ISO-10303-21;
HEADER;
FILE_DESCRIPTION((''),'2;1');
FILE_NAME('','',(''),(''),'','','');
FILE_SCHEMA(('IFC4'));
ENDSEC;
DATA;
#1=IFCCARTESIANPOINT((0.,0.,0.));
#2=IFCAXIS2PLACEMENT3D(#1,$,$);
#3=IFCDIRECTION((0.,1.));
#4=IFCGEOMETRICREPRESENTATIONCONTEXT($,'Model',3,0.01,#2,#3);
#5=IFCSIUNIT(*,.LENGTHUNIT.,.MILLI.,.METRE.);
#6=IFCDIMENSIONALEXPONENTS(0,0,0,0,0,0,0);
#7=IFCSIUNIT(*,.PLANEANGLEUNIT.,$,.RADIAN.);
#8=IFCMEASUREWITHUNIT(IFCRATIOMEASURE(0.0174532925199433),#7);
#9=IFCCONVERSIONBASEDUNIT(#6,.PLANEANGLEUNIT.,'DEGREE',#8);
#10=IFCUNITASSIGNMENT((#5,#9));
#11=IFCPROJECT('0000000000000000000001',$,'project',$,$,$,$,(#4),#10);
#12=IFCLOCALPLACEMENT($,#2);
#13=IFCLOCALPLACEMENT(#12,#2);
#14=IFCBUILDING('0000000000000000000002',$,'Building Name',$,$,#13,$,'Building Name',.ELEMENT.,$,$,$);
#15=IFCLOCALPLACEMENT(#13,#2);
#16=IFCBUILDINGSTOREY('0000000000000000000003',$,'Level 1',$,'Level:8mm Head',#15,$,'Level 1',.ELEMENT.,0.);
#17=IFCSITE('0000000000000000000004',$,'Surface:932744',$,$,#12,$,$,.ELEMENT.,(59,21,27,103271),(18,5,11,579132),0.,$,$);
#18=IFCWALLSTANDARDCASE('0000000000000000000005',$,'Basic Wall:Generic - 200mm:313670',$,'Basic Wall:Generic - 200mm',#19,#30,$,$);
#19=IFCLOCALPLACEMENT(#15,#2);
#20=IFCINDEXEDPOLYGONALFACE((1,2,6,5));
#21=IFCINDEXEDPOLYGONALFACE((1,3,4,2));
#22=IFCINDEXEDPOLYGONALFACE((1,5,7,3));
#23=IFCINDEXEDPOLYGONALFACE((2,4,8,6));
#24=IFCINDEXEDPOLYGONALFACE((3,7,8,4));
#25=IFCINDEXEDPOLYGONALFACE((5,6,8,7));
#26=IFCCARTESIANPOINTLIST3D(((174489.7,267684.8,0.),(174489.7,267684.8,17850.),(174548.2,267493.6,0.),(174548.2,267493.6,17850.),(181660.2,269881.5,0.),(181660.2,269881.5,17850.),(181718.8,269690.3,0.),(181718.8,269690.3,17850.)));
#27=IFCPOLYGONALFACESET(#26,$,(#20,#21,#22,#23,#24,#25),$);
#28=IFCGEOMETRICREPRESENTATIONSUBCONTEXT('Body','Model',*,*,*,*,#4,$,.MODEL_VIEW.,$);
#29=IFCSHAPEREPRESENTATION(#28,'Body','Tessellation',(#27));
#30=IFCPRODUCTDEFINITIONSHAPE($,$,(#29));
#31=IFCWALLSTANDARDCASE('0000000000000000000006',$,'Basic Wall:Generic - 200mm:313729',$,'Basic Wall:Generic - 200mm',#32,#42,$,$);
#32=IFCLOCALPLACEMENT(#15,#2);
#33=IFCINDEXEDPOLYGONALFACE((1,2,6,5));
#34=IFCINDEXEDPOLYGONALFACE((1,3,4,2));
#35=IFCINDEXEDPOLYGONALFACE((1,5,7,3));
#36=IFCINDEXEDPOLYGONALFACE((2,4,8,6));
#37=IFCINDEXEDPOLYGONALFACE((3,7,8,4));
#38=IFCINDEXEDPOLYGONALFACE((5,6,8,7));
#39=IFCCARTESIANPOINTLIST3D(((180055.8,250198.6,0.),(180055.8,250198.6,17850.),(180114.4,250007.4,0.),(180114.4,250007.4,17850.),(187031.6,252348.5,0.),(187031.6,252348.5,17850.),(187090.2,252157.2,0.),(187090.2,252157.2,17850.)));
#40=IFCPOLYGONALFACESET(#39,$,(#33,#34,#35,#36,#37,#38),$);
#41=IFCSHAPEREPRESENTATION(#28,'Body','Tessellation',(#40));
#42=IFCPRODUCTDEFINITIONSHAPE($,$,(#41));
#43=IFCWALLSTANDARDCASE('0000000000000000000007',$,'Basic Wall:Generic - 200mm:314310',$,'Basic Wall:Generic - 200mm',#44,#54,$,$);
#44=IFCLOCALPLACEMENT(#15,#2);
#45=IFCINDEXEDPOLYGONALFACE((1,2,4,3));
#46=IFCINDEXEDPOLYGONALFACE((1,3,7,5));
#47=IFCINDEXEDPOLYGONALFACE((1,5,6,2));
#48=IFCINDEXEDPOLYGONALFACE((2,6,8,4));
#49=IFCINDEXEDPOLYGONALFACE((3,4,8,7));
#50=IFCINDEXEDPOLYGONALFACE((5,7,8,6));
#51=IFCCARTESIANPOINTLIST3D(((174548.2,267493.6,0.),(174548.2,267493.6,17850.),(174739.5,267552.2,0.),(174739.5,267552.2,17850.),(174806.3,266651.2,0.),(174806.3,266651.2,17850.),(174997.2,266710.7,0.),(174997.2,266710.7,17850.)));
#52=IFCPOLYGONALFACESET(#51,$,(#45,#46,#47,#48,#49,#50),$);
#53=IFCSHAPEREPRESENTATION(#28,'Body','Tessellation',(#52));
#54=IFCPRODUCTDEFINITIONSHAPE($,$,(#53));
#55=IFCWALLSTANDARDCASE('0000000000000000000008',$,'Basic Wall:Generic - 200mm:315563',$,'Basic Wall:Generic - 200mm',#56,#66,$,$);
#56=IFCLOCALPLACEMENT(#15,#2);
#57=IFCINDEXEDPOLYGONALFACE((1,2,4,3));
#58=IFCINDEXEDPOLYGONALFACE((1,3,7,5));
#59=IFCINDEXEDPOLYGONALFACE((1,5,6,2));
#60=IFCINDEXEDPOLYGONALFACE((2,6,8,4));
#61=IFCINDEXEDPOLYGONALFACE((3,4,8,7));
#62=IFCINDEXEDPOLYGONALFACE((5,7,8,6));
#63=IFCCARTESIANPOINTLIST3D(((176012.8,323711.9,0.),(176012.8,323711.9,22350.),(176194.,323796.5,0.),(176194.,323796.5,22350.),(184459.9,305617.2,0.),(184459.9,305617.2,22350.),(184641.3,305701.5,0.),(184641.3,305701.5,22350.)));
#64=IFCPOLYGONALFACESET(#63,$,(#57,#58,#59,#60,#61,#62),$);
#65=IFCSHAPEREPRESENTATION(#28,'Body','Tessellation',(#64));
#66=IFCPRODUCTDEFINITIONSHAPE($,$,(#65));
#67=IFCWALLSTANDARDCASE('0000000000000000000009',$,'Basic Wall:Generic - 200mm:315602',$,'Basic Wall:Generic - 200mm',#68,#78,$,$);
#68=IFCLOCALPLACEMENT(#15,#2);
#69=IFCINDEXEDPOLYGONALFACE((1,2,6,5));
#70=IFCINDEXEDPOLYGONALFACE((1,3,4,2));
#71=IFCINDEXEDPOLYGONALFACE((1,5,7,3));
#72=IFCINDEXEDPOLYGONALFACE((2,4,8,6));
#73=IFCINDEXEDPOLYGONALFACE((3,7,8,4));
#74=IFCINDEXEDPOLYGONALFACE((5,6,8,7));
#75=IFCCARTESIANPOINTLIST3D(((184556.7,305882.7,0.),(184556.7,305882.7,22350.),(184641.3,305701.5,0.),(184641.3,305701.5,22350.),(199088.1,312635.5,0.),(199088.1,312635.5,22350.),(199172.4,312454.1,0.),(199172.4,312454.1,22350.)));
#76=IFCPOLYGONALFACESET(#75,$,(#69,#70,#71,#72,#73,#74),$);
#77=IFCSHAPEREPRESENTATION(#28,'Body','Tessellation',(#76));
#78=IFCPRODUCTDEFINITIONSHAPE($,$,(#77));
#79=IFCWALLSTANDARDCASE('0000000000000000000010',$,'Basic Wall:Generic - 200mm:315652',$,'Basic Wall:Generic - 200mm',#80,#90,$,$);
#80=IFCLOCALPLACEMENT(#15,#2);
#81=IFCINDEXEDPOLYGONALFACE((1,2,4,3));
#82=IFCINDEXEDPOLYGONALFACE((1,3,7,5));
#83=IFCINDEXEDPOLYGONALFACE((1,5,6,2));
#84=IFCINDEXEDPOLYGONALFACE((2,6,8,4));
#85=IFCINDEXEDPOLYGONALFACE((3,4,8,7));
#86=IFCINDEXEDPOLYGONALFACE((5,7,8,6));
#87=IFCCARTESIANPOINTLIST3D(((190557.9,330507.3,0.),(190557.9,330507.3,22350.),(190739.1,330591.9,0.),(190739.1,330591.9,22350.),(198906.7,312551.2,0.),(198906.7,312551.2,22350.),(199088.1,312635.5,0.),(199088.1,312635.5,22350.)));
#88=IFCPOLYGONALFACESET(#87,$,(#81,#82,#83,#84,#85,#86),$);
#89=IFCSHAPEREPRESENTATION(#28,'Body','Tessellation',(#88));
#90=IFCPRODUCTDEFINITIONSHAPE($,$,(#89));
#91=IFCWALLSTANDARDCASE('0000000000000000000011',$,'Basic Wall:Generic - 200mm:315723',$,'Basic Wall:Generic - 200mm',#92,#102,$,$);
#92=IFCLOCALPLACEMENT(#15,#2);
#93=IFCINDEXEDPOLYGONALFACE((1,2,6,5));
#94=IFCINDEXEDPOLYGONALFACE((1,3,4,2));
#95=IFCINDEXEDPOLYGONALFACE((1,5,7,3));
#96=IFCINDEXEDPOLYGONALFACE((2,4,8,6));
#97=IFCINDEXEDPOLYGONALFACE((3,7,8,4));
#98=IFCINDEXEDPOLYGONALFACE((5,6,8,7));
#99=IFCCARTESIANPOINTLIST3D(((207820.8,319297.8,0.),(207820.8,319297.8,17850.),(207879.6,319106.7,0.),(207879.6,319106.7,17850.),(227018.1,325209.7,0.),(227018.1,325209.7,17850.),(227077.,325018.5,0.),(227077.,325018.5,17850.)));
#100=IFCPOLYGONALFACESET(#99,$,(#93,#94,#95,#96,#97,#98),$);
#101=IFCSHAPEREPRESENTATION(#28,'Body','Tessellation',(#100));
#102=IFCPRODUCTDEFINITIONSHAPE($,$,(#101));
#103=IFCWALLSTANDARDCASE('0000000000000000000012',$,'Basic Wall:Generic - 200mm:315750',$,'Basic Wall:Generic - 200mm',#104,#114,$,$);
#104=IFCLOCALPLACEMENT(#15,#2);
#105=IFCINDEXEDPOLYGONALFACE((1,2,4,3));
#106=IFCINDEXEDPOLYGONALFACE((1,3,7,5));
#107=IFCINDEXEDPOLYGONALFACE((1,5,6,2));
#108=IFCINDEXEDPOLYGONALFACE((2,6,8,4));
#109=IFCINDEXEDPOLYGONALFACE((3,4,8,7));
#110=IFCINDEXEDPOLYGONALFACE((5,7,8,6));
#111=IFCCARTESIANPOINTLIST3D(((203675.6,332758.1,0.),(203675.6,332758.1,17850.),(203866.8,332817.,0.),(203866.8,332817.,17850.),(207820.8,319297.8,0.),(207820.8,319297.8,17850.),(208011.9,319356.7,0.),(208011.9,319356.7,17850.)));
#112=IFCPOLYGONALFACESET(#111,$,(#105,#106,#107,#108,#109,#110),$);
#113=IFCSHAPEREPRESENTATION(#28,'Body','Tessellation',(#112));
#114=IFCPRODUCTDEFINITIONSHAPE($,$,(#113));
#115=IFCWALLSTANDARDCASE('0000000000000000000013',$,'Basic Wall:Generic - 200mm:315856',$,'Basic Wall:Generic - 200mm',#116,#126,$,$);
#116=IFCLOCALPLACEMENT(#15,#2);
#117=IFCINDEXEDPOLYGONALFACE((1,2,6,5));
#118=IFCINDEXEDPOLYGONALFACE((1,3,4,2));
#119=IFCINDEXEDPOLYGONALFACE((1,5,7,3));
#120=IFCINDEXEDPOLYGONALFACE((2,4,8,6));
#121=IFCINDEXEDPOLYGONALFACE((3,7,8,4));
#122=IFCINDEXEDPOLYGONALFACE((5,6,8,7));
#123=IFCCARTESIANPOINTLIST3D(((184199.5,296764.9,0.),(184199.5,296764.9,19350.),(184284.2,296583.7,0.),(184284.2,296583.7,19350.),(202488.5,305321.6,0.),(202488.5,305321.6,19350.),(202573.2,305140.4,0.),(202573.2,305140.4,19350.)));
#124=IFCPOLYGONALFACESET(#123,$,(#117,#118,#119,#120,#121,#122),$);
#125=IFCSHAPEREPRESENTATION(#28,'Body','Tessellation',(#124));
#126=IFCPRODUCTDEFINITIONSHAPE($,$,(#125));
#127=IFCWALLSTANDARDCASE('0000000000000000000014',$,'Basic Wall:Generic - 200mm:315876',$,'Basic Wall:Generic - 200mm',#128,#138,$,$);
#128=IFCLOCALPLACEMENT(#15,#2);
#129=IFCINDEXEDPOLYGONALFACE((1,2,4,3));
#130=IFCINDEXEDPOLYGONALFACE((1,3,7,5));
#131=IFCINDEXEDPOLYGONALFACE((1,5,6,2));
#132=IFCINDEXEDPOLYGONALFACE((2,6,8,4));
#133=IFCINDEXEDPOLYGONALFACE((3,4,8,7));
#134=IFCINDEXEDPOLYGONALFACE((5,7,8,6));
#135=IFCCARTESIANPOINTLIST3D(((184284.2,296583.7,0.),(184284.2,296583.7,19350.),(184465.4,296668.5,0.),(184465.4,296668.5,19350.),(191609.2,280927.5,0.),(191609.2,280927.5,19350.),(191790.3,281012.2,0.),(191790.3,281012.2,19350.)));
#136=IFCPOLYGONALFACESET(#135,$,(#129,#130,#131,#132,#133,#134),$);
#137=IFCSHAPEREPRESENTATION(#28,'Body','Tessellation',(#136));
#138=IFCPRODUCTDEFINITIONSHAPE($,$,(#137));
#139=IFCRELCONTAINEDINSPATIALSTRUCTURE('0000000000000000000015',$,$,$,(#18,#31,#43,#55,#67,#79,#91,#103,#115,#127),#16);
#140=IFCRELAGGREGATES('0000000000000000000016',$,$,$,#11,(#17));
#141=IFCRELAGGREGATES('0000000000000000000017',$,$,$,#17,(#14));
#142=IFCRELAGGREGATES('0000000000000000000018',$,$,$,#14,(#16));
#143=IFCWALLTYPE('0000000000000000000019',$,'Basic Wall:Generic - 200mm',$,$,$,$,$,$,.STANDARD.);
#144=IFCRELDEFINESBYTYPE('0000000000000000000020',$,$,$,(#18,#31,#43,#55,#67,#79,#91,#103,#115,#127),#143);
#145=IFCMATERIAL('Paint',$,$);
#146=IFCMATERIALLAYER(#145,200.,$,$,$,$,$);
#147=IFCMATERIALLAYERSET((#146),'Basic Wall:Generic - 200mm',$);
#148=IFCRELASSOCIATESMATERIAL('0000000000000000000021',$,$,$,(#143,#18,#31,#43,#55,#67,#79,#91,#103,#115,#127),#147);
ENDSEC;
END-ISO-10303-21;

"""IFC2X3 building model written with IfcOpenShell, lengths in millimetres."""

from ifc_helpers import new_model, entity, si_unit, converted_unit, direction, frame, frame_2d, origin, place, context, subcontext, project, spatial, polyline, rectangle, outline, extrude, clip, bounded_halfspace, material, layer, layer_set, layer_usage, type_object, element, save


model = new_model("IFC2X3")

# Units and contexts
model_context = context("Model", 3, precision=0.01, world=origin(), true_north=direction((0.0, 1.0)))
body_context = subcontext(model_context, "Body", "Model", "MODEL_VIEW")
ifc_project = project(units=[si_unit("LENGTHUNIT", "METRE", prefix="MILLI"), converted_unit("PLANEANGLEUNIT", "DEGREE", entity("IfcRatioMeasure", 0.0174532925199433), si_unit("PLANEANGLEUNIT", "RADIAN"), dimensions=[0, 0, 0, 0, 0, 0, 0])], contexts=[model_context])

# Site, building, storey
site_placement = place(None, origin())
site = spatial("IfcSite", under=ifc_project, at=site_placement, Name="Surface:932744", CompositionType="ELEMENT", RefLatitude=(59, 21, 27, 103271), RefLongitude=(18, 5, 11, 579132), RefElevation=0.0)
building_placement = place(site_placement, origin())
building = spatial("IfcBuilding", under=site, at=building_placement, Name="Building Name", LongName="Building Name", CompositionType="ELEMENT")
storey_placement = place(building_placement, origin())
storey = spatial("IfcBuildingStorey", under=building, at=storey_placement, Name="Level 1", ObjectType="Level:8mm Head", LongName="Level 1", CompositionType="ELEMENT", Elevation=0.0)

# Shared definitions
ifc_material_1 = material(Name="Paint")
ifc_layer_1 = layer(ifc_material_1, 200.0)
ifc_layer_set_1 = layer_set([ifc_layer_1], Name="Basic Wall:Generic - 200mm")
wall_type_1 = type_object("IfcWallType", Name="Basic Wall:Generic - 200mm", PredefinedType="STANDARD", material=ifc_layer_set_1)

# Wall
ifc_layer_usage_1 = layer_usage(ifc_layer_set_1, "AXIS2", "NEGATIVE", 100.0)
wall_1_placement = place(storey_placement, frame((181689.5, 269785.9, 0.0), z_axis=(0.0, 0.0, 1.0), x_axis=(-0.956137, -0.292918, 0.0)))
element("IfcWallStandardCase", 1, at=wall_1_placement, inside=storey, type_object=wall_type_1, material=ifc_layer_usage_1, Name="Basic Wall:Generic - 200mm:313670", ObjectType="Basic Wall:Generic - 200mm", context=body_context, shape_type="Clipping", body=[
    clip(extrude(rectangle(XDim=7499.5, YDim=200.0, at=frame_2d((3749.8, 0.0), x_axis=(-1.0, 0.0))), origin(), (0.0, 0.0, 1.0), 17850.0), bounded_halfspace(frame((0.0, -100.0, 17850.0), z_axis=(0.0, 0.0, -1.0), x_axis=(-1.0, 0.0, 0.0)), True, frame((0.0, -100.0, 17850.0), z_axis=(0.0, 0.0, -1.0), x_axis=(-1.0, 0.0, 0.0)), polyline([(0.0, 0.0), (0.0, 200.0), (-7499.5, 200.0), (-7499.5, 0.0), (0.0, 0.0)]))),
])

# Walls
ifc_layer_usage_2 = layer_usage(ifc_layer_set_1, "AXIS2", "NEGATIVE", 100.0)
wall_2_placement = place(storey_placement, frame((180084.9, 250103.0, 0.0), z_axis=(0.0, 0.0, 1.0), x_axis=(0.955647, 0.294515, 0.0)))
element("IfcWallStandardCase", 2, at=wall_2_placement, inside=storey, type_object=wall_type_1, material=ifc_layer_usage_2, Name="Basic Wall:Generic - 200mm:313729", ObjectType="Basic Wall:Generic - 200mm", context=body_context, shape_type="Clipping", body=[
    clip(extrude(outline(polyline([(7299.5, -100.0), (7299.9, 100.0), (0.3, 100.0), (0.0, -100.0), (7299.5, -100.0)])), origin(), (0.0, 0.0, 1.0), 17850.0), bounded_halfspace(frame((0.0, -100.0, 17850.0), z_axis=(0.0, 0.0, -1.0), x_axis=(0.999999, -0.001671, 0.0)), True, frame((0.0, -100.0, 17850.0), z_axis=(0.0, 0.0, -1.0), x_axis=(0.999999, -0.001671, 0.0)), polyline([(0.0, 0.0), (0.0, -200.0), (7299.5, -212.2), (7299.5, -12.2), (0.0, 0.0)]))),
])
ifc_layer_usage_3 = layer_usage(ifc_layer_set_1, "AXIS2", "NEGATIVE", 100.0)
wall_3_placement = place(storey_placement, frame((174643.8, 267522.9, 0.0), z_axis=(0.0, 0.0, 1.0), x_axis=(0.292918, -0.956137, 0.0)))
element("IfcWallStandardCase", 3, at=wall_3_placement, inside=storey, type_object=wall_type_1, material=ifc_layer_usage_3, Name="Basic Wall:Generic - 200mm:314310", ObjectType="Basic Wall:Generic - 200mm", context=body_context, shape_type="Clipping", body=[
    clip(extrude(outline(polyline([(881.0, -100.0), (880.0, 100.0), (0.0, 100.0), (0.0, -100.0), (881.0, -100.0)])), origin(), (0.0, 0.0, 1.0), 17850.0), bounded_halfspace(frame((0.0, -100.0, 17850.0), z_axis=(0.0, 0.0, -1.0), x_axis=(0.0, 1.0, 0.0)), True, frame((0.0, -100.0, 17850.0), z_axis=(0.0, 0.0, -1.0), x_axis=(0.0, 1.0, 0.0)), polyline([(0.0, 0.0), (200.0, 0.0), (200.0, 880.0), (0.0, 881.0), (0.0, 0.0)]))),
])
ifc_layer_usage_4 = layer_usage(ifc_layer_set_1, "AXIS2", "NEGATIVE", 100.0)
wall_4_placement = place(storey_placement, frame((176103.4, 323754.2, 0.0), z_axis=(0.0, 0.0, 1.0), x_axis=(0.423007, -0.906126, 0.0)))
element("IfcWallStandardCase", 4, at=wall_4_placement, inside=storey, type_object=wall_type_1, material=ifc_layer_usage_4, Name="Basic Wall:Generic - 200mm:315563", ObjectType="Basic Wall:Generic - 200mm", context=body_context, shape_type="Clipping", body=[
    clip(extrude(outline(polyline([(19969.3, -100.0), (19969.7, 100.0), (19769.7, 100.0), (0.0, 100.0), (0.1, -100.0), (19969.3, -100.0)])), origin(), (0.0, 0.0, 1.0), 22350.0), bounded_halfspace(frame((0.1, -100.0, 22350.0), z_axis=(0.0, 0.0, -1.0), x_axis=(-0.000299, 1.0, 0.0)), True, frame((0.1, -100.0, 22350.0), z_axis=(0.0, 0.0, -1.0), x_axis=(-0.000299, 1.0, 0.0)), polyline([(0.0, 0.0), (200.0, 0.0), (194.0, 19969.7), (-6.0, 19969.3), (0.0, 0.0)]))),
])
ifc_layer_usage_5 = layer_usage(ifc_layer_set_1, "AXIS2", "NEGATIVE", 100.0)
wall_5_placement = place(storey_placement, frame((184598.8, 305792.0, 0.0), z_axis=(0.0, 0.0, 1.0), x_axis=(0.906865, 0.421422, 0.0)))
element("IfcWallStandardCase", 5, at=wall_5_placement, inside=storey, type_object=wall_type_1, material=ifc_layer_usage_5, Name="Basic Wall:Generic - 200mm:315602", ObjectType="Basic Wall:Generic - 200mm", context=body_context, shape_type="Clipping", body=[
    clip(extrude(outline(polyline([(16023.8, -100.0), (16023.8, 100.0), (15823.8, 100.0), (0.0, 100.0), (0.3, -100.0), (16023.8, -100.0)])), origin(), (0.0, 0.0, 1.0), 22350.0), bounded_halfspace(frame((0.3, -100.0, 22350.0), z_axis=(0.0, 0.0, -1.0), x_axis=(0.999998, 0.002048, 0.0)), True, frame((0.3, -100.0, 22350.0), z_axis=(0.0, 0.0, -1.0), x_axis=(0.999998, 0.002048, 0.0)), polyline([(0.0, 0.0), (0.1, -200.0), (15823.8, -167.6), (16023.8, -167.2), (16023.5, 32.8), (0.0, 0.0)]))),
])
ifc_layer_usage_6 = layer_usage(ifc_layer_set_1, "AXIS2", "NEGATIVE", 100.0)
wall_6_placement = place(storey_placement, frame((198997.4, 312593.3, 0.0), z_axis=(0.0, 0.0, 1.0), x_axis=(-0.421612, 0.906776, 0.0)))
element("IfcWallStandardCase", 6, at=wall_6_placement, inside=storey, type_object=wall_type_1, material=ifc_layer_usage_6, Name="Basic Wall:Generic - 200mm:315652", ObjectType="Basic Wall:Generic - 200mm", context=body_context, shape_type="Clipping", body=[
    clip(extrude(outline(polyline([(19802.5, -100.0), (19802.1, 100.0), (0.0, 100.0), (0.0, -100.0), (19802.5, -100.0)])), origin(), (0.0, 0.0, 1.0), 22350.0), bounded_halfspace(frame((0.0, -100.0, 22350.0), z_axis=(0.0, 0.0, -1.0), x_axis=(0.001838, -0.999998, 0.0)), True, frame((0.0, -100.0, 22350.0), z_axis=(0.0, 0.0, -1.0), x_axis=(0.001838, -0.999998, 0.0)), polyline([(0.0, 0.0), (-200.0, -0.4), (-163.6, -19802.5), (36.4, -19802.5), (0.0, 0.0)]))),
])
ifc_layer_usage_7 = layer_usage(ifc_layer_set_1, "AXIS2", "NEGATIVE", 100.0)
wall_7_placement = place(storey_placement, frame((227047.6, 325114.1, 0.0), z_axis=(0.0, 0.0, 1.0), x_axis=(-0.955709, -0.294313, 0.0)))
element("IfcWallStandardCase", 7, at=wall_7_placement, inside=storey, type_object=wall_type_1, material=ifc_layer_usage_7, Name="Basic Wall:Generic - 200mm:315723", ObjectType="Basic Wall:Generic - 200mm", context=body_context, shape_type="Clipping", body=[
    clip(extrude(rectangle(XDim=20087.1, YDim=200.0, at=frame_2d((10043.5, 0.0), x_axis=(-1.0, 0.0))), origin(), (0.0, 0.0, 1.0), 17850.0), bounded_halfspace(frame((0.0, -100.0, 17850.0), z_axis=(0.0, 0.0, -1.0), x_axis=(0.0, 1.0, 0.0)), True, frame((0.0, -100.0, 17850.0), z_axis=(0.0, 0.0, -1.0), x_axis=(0.0, 1.0, 0.0)), polyline([(0.0, 0.0), (200.0, 0.0), (200.0, 20087.1), (0.0, 20087.1), (0.0, 19887.1), (0.0, 200.0), (0.0, 0.0)]))),
])
ifc_layer_usage_8 = layer_usage(ifc_layer_set_1, "AXIS2", "NEGATIVE", 100.0)
wall_8_placement = place(storey_placement, frame((207916.3, 319327.2, 0.0), z_axis=(0.0, 0.0, 1.0), x_axis=(-0.294313, 0.955709, 0.0)))
element("IfcWallStandardCase", 8, at=wall_8_placement, inside=storey, type_object=wall_type_1, material=ifc_layer_usage_8, Name="Basic Wall:Generic - 200mm:315750", ObjectType="Basic Wall:Generic - 200mm", context=body_context, shape_type="Clipping", body=[
    clip(extrude(rectangle(XDim=14084.2, YDim=200.0, at=frame_2d((7042.1, 0.0), x_axis=(-1.0, 0.0))), origin(), (0.0, 0.0, 1.0), 17850.0), bounded_halfspace(frame((0.0, -100.0, 17850.0), z_axis=(0.0, 0.0, -1.0), x_axis=(-1.0, 0.0, 0.0)), True, frame((0.0, -100.0, 17850.0), z_axis=(0.0, 0.0, -1.0), x_axis=(-1.0, 0.0, 0.0)), polyline([(0.0, 0.0), (0.0, 200.0), (-14084.2, 200.0), (-14084.2, 0.0), (0.0, 0.0)]))),
])
ifc_layer_usage_9 = layer_usage(ifc_layer_set_1, "AXIS2", "NEGATIVE", 100.0)
wall_9_placement = place(storey_placement, frame((202530.9, 305231.0, 0.0), z_axis=(0.0, 0.0, 1.0), x_axis=(-0.905768, -0.423773, 0.0)))
element("IfcWallStandardCase", 9, at=wall_9_placement, inside=storey, type_object=wall_type_1, material=ifc_layer_usage_9, Name="Basic Wall:Generic - 200mm:315856", ObjectType="Basic Wall:Generic - 200mm", context=body_context, shape_type="Clipping", body=[
    clip(extrude(rectangle(XDim=20191.7, YDim=200.0, at=frame_2d((10095.8, 0.0), x_axis=(-1.0, 0.0))), origin(), (0.0, 0.0, 1.0), 19350.0), bounded_halfspace(frame((0.0, -100.0, 19350.0), z_axis=(0.0, 0.0, -1.0), x_axis=(-1.0, 0.0, 0.0)), True, frame((0.0, -100.0, 19350.0), z_axis=(0.0, 0.0, -1.0), x_axis=(-1.0, 0.0, 0.0)), polyline([(0.0, 0.0), (0.0, 200.0), (-200.0, 200.0), (-19991.7, 200.0), (-20191.7, 200.0), (-20191.7, 0.0), (0.0, 0.0)]))),
])
ifc_layer_usage_10 = layer_usage(ifc_layer_set_1, "AXIS2", "NEGATIVE", 100.0)
wall_10_placement = place(storey_placement, frame((184374.8, 296626.1, 0.0), z_axis=(0.0, 0.0, 1.0), x_axis=(0.423773, -0.905768, 0.0)))
element("IfcWallStandardCase", 10, at=wall_10_placement, inside=storey, type_object=wall_type_1, material=ifc_layer_usage_10, Name="Basic Wall:Generic - 200mm:315876", ObjectType="Basic Wall:Generic - 200mm", context=body_context, shape_type="Clipping", body=[
    clip(extrude(rectangle(XDim=17285.0, YDim=200.0, at=frame_2d((8642.5, 0.0), x_axis=(-1.0, 0.0))), origin(), (0.0, 0.0, 1.0), 19350.0), bounded_halfspace(frame((0.0, -100.0, 19350.0), z_axis=(0.0, 0.0, -1.0), x_axis=(0.0, 1.0, 0.0)), True, frame((0.0, -100.0, 19350.0), z_axis=(0.0, 0.0, -1.0), x_axis=(0.0, 1.0, 0.0)), polyline([(0.0, 0.0), (200.0, 0.0), (200.0, 17285.0), (0.0, 17285.0), (0.0, 0.0)]))),
])

save(model, "model.ifc")
